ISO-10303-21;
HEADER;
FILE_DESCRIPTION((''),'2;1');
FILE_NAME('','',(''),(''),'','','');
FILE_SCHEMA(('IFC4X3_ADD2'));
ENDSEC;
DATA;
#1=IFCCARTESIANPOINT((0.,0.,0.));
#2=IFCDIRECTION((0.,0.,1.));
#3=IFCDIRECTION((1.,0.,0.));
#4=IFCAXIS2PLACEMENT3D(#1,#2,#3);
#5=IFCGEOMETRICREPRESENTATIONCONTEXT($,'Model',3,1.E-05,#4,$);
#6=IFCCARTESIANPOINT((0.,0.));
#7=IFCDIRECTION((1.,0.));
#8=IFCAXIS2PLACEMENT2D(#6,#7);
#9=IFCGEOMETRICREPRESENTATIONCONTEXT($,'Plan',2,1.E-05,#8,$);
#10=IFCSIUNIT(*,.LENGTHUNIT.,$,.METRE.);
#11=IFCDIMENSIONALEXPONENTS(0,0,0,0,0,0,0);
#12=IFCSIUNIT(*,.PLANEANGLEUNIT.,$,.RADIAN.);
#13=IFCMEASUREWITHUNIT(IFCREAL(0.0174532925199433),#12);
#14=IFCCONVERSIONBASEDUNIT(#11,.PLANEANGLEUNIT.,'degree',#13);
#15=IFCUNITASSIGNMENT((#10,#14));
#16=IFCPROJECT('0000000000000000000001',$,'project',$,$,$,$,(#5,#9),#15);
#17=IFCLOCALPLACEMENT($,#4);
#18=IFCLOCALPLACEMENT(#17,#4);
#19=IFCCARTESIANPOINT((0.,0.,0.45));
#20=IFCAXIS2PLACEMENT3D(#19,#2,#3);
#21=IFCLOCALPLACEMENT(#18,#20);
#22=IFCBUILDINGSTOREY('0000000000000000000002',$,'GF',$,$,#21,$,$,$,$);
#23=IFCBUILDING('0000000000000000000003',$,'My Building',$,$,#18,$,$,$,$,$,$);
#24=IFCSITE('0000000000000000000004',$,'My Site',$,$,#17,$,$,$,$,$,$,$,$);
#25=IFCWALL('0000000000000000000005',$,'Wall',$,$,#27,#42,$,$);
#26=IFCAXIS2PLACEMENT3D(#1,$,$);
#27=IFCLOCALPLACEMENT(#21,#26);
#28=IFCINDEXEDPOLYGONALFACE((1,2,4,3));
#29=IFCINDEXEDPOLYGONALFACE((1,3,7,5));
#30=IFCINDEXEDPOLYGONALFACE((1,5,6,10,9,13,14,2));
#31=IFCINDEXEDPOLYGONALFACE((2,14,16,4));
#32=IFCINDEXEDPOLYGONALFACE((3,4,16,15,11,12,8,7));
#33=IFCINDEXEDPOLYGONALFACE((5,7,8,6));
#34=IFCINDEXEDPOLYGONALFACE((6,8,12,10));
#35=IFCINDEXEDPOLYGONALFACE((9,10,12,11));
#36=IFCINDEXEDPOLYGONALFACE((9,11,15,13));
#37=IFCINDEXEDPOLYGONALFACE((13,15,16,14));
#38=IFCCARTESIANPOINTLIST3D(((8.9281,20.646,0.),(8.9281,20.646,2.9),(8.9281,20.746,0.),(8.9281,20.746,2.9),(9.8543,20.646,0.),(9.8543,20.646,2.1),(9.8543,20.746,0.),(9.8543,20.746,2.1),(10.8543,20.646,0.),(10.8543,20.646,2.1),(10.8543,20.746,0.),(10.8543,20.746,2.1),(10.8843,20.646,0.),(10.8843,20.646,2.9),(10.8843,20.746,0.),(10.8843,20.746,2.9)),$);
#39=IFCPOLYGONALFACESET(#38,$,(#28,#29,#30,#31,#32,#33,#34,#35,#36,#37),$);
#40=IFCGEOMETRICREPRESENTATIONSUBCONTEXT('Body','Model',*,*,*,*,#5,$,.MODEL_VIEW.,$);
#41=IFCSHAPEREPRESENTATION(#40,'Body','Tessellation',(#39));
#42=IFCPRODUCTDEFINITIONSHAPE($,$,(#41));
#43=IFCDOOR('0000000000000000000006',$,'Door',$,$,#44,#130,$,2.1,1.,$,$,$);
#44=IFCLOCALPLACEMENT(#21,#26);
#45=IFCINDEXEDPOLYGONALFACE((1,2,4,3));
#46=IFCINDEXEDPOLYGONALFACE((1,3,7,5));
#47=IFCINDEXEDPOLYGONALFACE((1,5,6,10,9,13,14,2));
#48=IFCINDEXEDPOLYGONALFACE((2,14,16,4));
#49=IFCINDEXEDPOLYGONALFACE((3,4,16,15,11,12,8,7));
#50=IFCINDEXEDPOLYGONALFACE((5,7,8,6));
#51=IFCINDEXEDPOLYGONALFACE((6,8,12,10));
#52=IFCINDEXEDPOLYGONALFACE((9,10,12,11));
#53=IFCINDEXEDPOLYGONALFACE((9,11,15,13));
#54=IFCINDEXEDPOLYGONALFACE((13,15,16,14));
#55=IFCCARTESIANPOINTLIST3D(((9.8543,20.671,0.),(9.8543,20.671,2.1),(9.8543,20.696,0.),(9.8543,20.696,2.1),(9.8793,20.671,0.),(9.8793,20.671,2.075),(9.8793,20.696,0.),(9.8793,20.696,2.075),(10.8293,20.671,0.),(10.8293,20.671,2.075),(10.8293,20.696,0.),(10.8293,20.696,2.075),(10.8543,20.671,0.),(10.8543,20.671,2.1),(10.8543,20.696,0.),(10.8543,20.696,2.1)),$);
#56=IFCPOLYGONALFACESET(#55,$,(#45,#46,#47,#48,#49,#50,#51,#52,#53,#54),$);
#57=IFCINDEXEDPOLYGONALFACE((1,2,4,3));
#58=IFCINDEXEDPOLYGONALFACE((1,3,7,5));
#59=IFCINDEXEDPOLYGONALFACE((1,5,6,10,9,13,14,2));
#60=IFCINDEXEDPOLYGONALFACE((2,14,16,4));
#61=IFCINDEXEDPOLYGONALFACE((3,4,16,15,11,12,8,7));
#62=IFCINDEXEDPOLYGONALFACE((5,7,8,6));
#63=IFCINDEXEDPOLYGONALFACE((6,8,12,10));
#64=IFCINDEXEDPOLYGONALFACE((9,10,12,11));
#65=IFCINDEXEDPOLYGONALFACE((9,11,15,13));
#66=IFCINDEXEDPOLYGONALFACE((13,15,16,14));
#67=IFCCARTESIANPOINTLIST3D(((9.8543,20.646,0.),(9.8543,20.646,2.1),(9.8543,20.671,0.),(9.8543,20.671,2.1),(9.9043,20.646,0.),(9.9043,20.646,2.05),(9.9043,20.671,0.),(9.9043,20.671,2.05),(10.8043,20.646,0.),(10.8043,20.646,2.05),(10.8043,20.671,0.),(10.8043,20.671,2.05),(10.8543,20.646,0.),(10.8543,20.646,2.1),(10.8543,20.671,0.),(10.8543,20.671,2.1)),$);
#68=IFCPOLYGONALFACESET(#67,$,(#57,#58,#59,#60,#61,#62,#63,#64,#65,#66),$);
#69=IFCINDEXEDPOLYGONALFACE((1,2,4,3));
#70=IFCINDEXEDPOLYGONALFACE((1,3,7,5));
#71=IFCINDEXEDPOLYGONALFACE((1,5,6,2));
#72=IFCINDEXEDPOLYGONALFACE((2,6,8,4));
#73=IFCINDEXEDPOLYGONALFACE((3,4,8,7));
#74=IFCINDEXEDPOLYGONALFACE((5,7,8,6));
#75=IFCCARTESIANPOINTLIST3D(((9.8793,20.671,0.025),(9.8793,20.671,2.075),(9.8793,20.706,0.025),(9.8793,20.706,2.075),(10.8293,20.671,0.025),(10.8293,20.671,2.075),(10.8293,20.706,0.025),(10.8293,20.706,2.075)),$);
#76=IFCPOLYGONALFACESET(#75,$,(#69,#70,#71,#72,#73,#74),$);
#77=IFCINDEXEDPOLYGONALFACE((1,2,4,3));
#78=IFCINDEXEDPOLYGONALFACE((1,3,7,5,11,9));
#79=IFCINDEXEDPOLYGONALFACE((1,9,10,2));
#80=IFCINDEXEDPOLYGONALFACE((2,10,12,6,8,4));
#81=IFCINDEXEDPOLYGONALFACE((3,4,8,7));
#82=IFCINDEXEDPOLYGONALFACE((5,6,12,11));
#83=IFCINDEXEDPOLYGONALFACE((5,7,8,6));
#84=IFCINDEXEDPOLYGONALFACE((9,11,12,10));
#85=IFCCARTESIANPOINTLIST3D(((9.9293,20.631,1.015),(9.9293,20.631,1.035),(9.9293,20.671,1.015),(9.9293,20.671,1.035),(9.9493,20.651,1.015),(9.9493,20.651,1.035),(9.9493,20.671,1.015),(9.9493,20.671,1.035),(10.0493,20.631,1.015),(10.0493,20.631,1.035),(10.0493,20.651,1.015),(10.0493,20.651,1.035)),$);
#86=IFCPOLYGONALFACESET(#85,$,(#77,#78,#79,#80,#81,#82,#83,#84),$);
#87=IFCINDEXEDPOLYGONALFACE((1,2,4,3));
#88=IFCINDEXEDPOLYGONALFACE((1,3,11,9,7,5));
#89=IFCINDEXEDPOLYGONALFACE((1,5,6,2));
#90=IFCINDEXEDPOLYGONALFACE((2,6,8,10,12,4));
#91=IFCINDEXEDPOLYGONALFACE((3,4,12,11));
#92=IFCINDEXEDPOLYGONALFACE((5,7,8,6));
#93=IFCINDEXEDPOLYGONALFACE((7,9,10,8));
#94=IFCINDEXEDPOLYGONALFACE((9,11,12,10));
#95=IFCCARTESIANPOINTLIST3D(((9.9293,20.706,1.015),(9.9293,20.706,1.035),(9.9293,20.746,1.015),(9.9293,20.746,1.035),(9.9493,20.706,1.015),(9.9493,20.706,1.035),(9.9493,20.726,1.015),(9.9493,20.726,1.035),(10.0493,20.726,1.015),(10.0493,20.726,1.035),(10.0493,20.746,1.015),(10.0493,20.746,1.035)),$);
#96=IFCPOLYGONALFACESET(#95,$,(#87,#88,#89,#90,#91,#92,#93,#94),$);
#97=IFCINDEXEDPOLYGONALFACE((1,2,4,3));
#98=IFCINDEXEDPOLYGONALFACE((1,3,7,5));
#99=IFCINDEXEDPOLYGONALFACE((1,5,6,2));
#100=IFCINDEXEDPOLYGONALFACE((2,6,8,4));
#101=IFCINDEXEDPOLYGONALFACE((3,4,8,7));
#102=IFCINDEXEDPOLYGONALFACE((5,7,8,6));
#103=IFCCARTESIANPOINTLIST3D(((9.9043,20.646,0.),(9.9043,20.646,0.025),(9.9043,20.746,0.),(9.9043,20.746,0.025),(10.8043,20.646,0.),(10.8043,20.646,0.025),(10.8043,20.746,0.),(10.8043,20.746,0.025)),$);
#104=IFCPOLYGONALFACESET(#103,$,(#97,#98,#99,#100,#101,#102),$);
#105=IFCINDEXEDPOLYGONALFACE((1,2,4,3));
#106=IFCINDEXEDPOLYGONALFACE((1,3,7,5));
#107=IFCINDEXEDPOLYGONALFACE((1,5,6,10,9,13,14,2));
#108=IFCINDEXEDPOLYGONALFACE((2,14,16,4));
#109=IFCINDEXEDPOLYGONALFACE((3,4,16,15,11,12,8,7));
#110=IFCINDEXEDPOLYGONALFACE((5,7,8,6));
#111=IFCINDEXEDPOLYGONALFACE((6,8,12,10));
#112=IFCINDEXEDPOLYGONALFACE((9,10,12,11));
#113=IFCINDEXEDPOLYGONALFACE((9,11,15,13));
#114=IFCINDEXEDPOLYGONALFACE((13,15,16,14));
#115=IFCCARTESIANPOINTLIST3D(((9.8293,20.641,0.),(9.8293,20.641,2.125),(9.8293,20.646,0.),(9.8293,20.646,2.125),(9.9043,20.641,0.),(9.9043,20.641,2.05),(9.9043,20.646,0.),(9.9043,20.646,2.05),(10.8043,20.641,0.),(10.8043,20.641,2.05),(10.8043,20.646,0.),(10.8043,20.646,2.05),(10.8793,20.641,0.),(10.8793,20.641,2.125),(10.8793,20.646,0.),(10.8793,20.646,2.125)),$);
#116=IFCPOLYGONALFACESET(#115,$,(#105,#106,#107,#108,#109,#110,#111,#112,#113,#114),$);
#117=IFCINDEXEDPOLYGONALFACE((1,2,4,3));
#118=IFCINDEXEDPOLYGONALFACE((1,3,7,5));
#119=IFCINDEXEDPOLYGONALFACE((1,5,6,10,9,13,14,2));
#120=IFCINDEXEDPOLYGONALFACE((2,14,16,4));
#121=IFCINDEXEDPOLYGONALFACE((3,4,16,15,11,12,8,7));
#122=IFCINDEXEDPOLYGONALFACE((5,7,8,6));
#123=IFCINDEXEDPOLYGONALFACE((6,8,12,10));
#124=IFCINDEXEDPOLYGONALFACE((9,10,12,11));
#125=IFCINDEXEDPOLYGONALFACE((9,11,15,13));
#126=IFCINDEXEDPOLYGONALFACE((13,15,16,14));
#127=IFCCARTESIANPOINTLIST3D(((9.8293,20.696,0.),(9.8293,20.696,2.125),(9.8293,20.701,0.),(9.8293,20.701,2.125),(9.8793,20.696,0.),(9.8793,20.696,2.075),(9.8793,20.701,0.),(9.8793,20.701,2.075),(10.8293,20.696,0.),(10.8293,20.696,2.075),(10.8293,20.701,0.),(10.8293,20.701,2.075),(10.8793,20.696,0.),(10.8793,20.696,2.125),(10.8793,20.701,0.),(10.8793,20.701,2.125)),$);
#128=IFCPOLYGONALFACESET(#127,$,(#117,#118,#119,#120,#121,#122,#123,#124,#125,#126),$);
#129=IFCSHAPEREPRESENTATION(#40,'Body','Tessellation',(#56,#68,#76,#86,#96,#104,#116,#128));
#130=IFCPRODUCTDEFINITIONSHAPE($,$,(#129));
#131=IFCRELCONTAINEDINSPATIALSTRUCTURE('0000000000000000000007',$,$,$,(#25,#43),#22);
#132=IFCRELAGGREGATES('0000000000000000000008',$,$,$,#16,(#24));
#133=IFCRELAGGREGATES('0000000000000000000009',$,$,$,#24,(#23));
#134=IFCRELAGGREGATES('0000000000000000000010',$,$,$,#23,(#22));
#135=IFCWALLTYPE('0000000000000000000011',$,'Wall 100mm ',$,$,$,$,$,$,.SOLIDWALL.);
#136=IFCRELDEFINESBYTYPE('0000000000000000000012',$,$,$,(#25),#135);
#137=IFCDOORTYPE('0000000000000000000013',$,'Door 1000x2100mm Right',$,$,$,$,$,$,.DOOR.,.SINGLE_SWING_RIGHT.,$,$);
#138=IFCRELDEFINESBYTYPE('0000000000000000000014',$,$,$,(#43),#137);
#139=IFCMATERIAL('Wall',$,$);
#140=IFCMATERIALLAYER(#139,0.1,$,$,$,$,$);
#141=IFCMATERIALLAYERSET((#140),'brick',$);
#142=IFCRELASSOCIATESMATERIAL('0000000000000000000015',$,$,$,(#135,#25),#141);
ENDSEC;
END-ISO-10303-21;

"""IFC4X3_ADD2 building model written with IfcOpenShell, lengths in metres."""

from ifc_helpers import new_model, entity, si_unit, converted_unit, frame, origin_with_axes, origin_2d_with_axis, place, context, subcontext, project, spatial, line, indexed_curve, outline, extrude, shape, source, transform, mapped, material, layer, layer_set, layer_usage, type_object, type_shapes, element, fill, save


model = new_model("IFC4X3_ADD2")

# Units and contexts
model_context = context("Model", 3, precision=1e-05, world=origin_with_axes())
plan_context = context("Plan", 2, precision=1e-05, world=origin_2d_with_axis())
body_context_1 = subcontext(model_context, "Body", "Model", "MODEL_VIEW")
body_context_2 = subcontext(plan_context, "Body", "Plan", "PLAN_VIEW")
ifc_project = project(units=[si_unit("LENGTHUNIT", "METRE"), converted_unit("PLANEANGLEUNIT", "degree", entity("IfcReal", 0.0174532925199433), si_unit("PLANEANGLEUNIT", "RADIAN"), dimensions=[0, 0, 0, 0, 0, 0, 0])], contexts=[model_context, plan_context])

# Site, building, storey
site_placement = place(None, origin_with_axes())
site = spatial("IfcSite", under=ifc_project, at=site_placement, Name="My Site")
building_placement = place(site_placement, origin_with_axes())
building = spatial("IfcBuilding", under=site, at=building_placement, Name="My Building")
storey_placement = place(building_placement, frame((0.0, 0.0, 0.45), z_axis=(0.0, 0.0, 1.0), x_axis=(1.0, 0.0, 0.0)))
storey = spatial("IfcBuildingStorey", under=building, at=storey_placement, Name="GF")

# Shared definitions
ifc_material_1 = material(Name="Wall")

# Shared definitions
ifc_layer_1 = layer(ifc_material_1, 0.1)
ifc_layer_set_1 = layer_set([ifc_layer_1], Name="brick")
wall_type_1 = type_object("IfcWallType", Name="Wall 100mm ", PredefinedType="SOLIDWALL", material=ifc_layer_set_1)

# Wall, opening, door
shared_shape_1 = source(origin_with_axes(), body_context_1, "Body", "SweptSolid", [
    extrude(outline(indexed_curve([(0.0, 0.0), (1.0, 0.0), (1.0, 2.1), (0.0, 2.1)], segments=[line(1, 2, 3, 4, 1)])), frame((0.0, -0.6, 0.0), z_axis=(0.0, -1.0, 0.0), x_axis=(1.0, 0.0, 0.0)), (0.0, 0.0, -1.0), 1.2),
])
door_type_1 = type_object("IfcDoorType", Name="Door 1000x2100mm Right", OperationType="SINGLE_SWING_RIGHT", PredefinedType="DOOR")
shared_shape_2 = source(origin_with_axes(), body_context_1, "Body", "SweptSolid", [
    extrude(outline(indexed_curve([(0.0, 0.0), (0.0, 2.1), (1.0, 2.1), (1.0, 0.0), (0.975, 0.0), (0.975, 2.075), (0.025, 2.075), (0.025, 0.0)], segments=[line(1, 2, 3, 4, 5, 6, 7, 8, 1)])), frame((0.0, 0.025, 0.0), z_axis=(0.0, -1.0, 0.0), x_axis=(1.0, 0.0, 0.0)), (0.0, 0.0, -1.0), 0.025),
    extrude(outline(indexed_curve([(0.0, 0.0), (0.0, 2.1), (1.0, 2.1), (1.0, 0.0), (0.95, 0.0), (0.95, 2.05), (0.05, 2.05), (0.05, 0.0)], segments=[line(1, 2, 3, 4, 5, 6, 7, 8, 1)])), frame((0.0, 0.0, 0.0), z_axis=(0.0, -1.0, 0.0), x_axis=(1.0, 0.0, 0.0)), (0.0, 0.0, -1.0), 0.025),
    extrude(outline(indexed_curve([(0.0, 0.0), (0.95, 0.0), (0.95, 0.035), (0.0, 0.035)], segments=[line(1, 2, 3, 4, 1)])), frame((0.025, 0.025, 0.025), z_axis=(0.0, 0.0, 1.0), x_axis=(1.0, 0.0, 0.0)), (0.0, 0.0, 1.0), 2.05),
    extrude(outline(indexed_curve([(0.0, 0.0), (0.0, -0.04), (0.12, -0.04), (0.12, -0.02), (0.02, -0.02), (0.02, 0.0)], segments=[line(1, 2, 3, 4, 5, 6, 1)])), frame((0.075, 0.025, 1.015), z_axis=(0.0, 0.0, 1.0), x_axis=(1.0, 0.0, 0.0)), (0.0, 0.0, 1.0), 0.02),
    extrude(outline(indexed_curve([(0.0, 0.0), (0.0, 0.04), (0.12, 0.04), (0.12, 0.02), (0.02, 0.02), (0.02, 0.0)], segments=[line(1, 2, 3, 4, 5, 6, 1)])), frame((0.075, 0.06, 1.015), z_axis=(0.0, 0.0, 1.0), x_axis=(1.0, 0.0, 0.0)), (0.0, 0.0, 1.0), 0.02),
    extrude(outline(indexed_curve([(0.0, 0.0), (0.9, 0.0), (0.9, 0.1), (0.0, 0.1)], segments=[line(1, 2, 3, 4, 1)])), frame((0.05, 0.0, 0.0), z_axis=(0.0, 0.0, 1.0), x_axis=(1.0, 0.0, 0.0)), (0.0, 0.0, 1.0), 0.025),
    extrude(outline(indexed_curve([(0.0, 0.0), (0.0, 2.125), (1.05, 2.125), (1.05, 0.0), (0.975, 0.0), (0.975, 2.05), (0.075, 2.05), (0.075, 0.0)], segments=[line(1, 2, 3, 4, 5, 6, 7, 8, 1)])), frame((-0.025, -0.005, 0.0), z_axis=(0.0, -1.0, 0.0), x_axis=(1.0, 0.0, 0.0)), (0.0, 0.0, -1.0), 0.005),
    extrude(outline(indexed_curve([(0.0, 0.0), (0.0, 2.125), (1.05, 2.125), (1.05, 0.0), (1.0, 0.0), (1.0, 2.075), (0.05, 2.075), (0.05, 0.0)], segments=[line(1, 2, 3, 4, 5, 6, 7, 8, 1)])), frame((-0.025, 0.05, 0.0), z_axis=(0.0, -1.0, 0.0), x_axis=(1.0, 0.0, 0.0)), (0.0, 0.0, -1.0), 0.005),
])
shared_shape_3 = source(origin_with_axes(), body_context_2, "Body", "Curve2D", [
    entity("IfcIndexedPolyCurve", entity("IfcCartesianPointList2D", [[0.0, 0.0], [0.0, 0.05], [0.025, 0.05], [0.025, 0.025], [0.05, 0.025], [0.05, 0.0]]), [entity("IfcLineIndex", [1, 2, 3, 4, 5, 6, 1])]),
    entity("IfcIndexedPolyCurve", entity("IfcCartesianPointList2D", [[1.0, 0.0], [1.0, 0.05], [0.975, 0.05], [0.975, 0.025], [0.95, 0.025], [0.95, 0.0]]), [entity("IfcLineIndex", [1, 2, 3, 4, 5, 6, 1])]),
    entity("IfcTrimmedCurve", entity("IfcEllipse", entity("IfcAxis2Placement2D", entity("IfcCartesianPoint", [0.94, 0.05]), entity("IfcDirection", [1.0, 0.0])), 0.915, 0.95), [entity("IfcCartesianPoint", [0.94, 1.0])], [entity("IfcCartesianPoint", [0.025, 0.05])], True, "CARTESIAN"),
    entity("IfcIndexedPolyCurve", entity("IfcCartesianPointList2D", [[0.975, 0.05], [0.94, 0.05], [0.94, 1.0], [0.975, 1.0]]), [entity("IfcLineIndex", [1, 2, 3, 4, 1])]),
])
type_shapes(door_type_1, [shared_shape_2, shared_shape_3])
ifc_layer_usage_1 = layer_usage(ifc_layer_set_1, "AXIS2", "POSITIVE", 0.0)
wall_1_placement = place(storey_placement, frame((8.9281, 20.646, 0.0), z_axis=(0.0, 0.0, 1.0), x_axis=(1.0, 0.0, 0.0)))
wall_1 = element("IfcWall", 1, at=wall_1_placement, inside=storey, type_object=wall_type_1, material=ifc_layer_usage_1, Name="Wall", context=body_context_1, shape_type="SweptSolid", body=[
    extrude(outline(indexed_curve([(0.0, 0.0), (0.0, 0.1), (1.9562, 0.1), (1.9562, 0.0), (0.0, 0.0)], self_intersect=False)), origin_with_axes(), (0.0, 0.0, 1.0), 2.9),
])
opening_1_placement = place(wall_1_placement, frame((0.9262, 0.0, 0.0), z_axis=(0.0, 0.0, 1.0), x_axis=(1.0, 0.0, 0.0)))
opening_1 = element("IfcOpeningElement", 2, at=opening_1_placement, cuts=wall_1, PredefinedType="OPENING", context=body_context_1, shape_type="MappedRepresentation", body=[
    mapped(shared_shape_1, transform((0.0, 0.0, 0.0), x_axis=(1.0, 0.0, 0.0), y_axis=(0.0, 1.0, 0.0), z_axis=(0.0, 0.0, 1.0), scale=1.0)),
])
door_1_placement = place(opening_1_placement, origin_with_axes())
door_1 = element("IfcDoor", 3, at=door_1_placement, inside=storey, type_object=door_type_1, Name="Door", OverallHeight=2.1, OverallWidth=1.0, shapes=[
    shape(body_context_1, "Body", "MappedRepresentation", [mapped(shared_shape_2, transform((0.0, 0.0, 0.0), x_axis=(1.0, 0.0, 0.0), y_axis=(0.0, 1.0, 0.0), z_axis=(0.0, 0.0, 1.0), scale=1.0))]),
    shape(body_context_2, "Body", "MappedRepresentation", [mapped(shared_shape_3, transform((0.0, 0.0, 0.0), x_axis=(1.0, 0.0, 0.0), y_axis=(0.0, 1.0, 0.0), z_axis=(0.0, 0.0, 1.0), scale=1.0))]),
])
fill(opening_1, door_1)

save(model, "model.ifc")
